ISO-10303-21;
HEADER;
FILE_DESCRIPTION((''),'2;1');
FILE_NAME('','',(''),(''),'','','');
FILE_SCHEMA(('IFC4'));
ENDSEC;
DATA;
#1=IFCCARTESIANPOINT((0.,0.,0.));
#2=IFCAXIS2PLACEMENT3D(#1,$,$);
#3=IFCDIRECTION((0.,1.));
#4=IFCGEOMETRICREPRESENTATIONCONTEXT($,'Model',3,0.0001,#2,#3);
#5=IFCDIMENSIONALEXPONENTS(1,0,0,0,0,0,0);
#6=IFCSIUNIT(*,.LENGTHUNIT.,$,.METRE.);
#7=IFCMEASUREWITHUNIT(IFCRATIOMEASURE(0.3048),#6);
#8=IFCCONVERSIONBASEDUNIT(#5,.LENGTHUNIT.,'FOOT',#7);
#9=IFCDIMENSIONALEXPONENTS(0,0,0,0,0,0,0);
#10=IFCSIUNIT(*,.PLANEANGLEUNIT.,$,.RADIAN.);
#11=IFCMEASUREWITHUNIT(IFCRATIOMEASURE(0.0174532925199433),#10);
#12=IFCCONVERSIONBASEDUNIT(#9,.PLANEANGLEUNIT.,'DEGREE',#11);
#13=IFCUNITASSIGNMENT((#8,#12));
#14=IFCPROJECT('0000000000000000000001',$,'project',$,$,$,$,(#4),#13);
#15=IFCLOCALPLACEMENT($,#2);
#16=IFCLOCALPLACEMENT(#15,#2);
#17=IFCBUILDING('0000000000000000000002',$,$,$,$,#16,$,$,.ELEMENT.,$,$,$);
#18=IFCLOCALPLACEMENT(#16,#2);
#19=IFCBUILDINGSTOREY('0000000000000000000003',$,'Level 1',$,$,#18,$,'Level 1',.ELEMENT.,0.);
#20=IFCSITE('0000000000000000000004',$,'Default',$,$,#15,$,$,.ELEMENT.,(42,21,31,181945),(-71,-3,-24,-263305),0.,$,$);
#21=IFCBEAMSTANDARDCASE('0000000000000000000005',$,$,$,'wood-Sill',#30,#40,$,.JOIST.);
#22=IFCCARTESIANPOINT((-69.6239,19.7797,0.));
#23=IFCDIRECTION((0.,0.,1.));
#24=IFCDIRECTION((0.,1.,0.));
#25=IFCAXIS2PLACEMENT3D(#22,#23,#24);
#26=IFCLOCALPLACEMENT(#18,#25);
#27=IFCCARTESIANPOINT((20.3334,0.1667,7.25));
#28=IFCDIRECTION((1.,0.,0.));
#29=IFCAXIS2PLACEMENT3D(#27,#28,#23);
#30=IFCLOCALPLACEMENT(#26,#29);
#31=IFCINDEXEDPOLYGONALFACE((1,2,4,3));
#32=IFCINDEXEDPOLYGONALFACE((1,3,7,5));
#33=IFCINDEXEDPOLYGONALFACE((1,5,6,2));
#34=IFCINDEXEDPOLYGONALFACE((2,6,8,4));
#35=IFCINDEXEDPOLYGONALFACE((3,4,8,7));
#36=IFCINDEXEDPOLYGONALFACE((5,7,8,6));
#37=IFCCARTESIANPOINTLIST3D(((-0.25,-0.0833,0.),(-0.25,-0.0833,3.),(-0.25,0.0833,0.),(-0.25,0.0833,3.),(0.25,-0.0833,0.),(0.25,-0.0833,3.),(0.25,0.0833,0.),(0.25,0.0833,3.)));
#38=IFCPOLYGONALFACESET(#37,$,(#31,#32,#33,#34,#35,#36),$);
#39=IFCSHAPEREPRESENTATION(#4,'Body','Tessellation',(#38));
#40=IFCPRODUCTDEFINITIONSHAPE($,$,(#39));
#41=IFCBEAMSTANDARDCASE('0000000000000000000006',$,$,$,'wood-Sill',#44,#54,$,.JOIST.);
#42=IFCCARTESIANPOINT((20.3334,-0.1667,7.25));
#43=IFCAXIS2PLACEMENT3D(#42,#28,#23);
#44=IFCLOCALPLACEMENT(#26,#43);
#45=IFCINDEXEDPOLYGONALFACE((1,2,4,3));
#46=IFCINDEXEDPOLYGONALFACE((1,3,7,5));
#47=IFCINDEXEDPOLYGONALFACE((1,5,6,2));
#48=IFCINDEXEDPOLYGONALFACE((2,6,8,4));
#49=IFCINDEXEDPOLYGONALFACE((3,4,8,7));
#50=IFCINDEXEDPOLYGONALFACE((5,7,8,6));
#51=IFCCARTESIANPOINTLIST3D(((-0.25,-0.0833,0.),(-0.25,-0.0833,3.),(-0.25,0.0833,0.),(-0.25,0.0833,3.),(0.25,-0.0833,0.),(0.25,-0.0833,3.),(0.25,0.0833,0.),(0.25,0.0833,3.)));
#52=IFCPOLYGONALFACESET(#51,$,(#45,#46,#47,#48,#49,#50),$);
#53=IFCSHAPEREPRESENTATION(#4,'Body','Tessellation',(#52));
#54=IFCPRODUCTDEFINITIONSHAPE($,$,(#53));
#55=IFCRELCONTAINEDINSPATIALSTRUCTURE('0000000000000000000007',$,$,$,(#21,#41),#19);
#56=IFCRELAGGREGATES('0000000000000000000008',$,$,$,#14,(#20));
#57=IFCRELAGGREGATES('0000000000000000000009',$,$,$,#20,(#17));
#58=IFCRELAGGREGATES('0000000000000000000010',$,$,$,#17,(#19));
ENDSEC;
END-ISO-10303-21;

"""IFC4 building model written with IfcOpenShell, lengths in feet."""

from ifc_helpers import new_model, entity, si_unit, converted_unit, direction, frame, origin, origin_with_axes, place, context, project, spatial, rectangle, extrude, element, save


model = new_model("IFC4")

# Units and contexts
model_context = context("Model", 3, precision=0.0001, world=origin(), true_north=direction((0.0, 1.0)))
ifc_project = project(units=[converted_unit("LENGTHUNIT", "FOOT", entity("IfcRatioMeasure", 0.3048), si_unit("LENGTHUNIT", "METRE"), dimensions=[1, 0, 0, 0, 0, 0, 0]), converted_unit("PLANEANGLEUNIT", "DEGREE", entity("IfcRatioMeasure", 0.0174532925199433), si_unit("PLANEANGLEUNIT", "RADIAN"), dimensions=[0, 0, 0, 0, 0, 0, 0])], contexts=[model_context])

# Site, building, storey
site_placement = place(None, origin())
site = spatial("IfcSite", under=ifc_project, at=site_placement, Name="Default", CompositionType="ELEMENT", RefLatitude=(42, 21, 31, 181945), RefLongitude=(-71, -3, -24, -263305), RefElevation=0.0)
building_placement = place(site_placement, origin())
building = spatial("IfcBuilding", under=site, at=building_placement, CompositionType="ELEMENT")
storey_placement = place(building_placement, origin())
storey = spatial("IfcBuildingStorey", under=building, at=storey_placement, Name="Level 1", LongName="Level 1", CompositionType="ELEMENT", Elevation=0.0)

# Shared definitions
placement_1 = place(storey_placement, frame((-69.6239, 19.7797, 0.0), z_axis=(0.0, 0.0, 1.0), x_axis=(0.0, 1.0, 0.0)))

# Beams
for number, where, z_axis, x_axis in (
    (1, (20.3334, 0.1667, 7.25), (1.0, 0.0, 0.0), (0.0, 0.0, 1.0)),
    (2, (20.3334, -0.1667, 7.25), (1.0, 0.0, 0.0), (0.0, 0.0, 1.0)),
):
    element("IfcBeamStandardCase", number, at=place(placement_1, frame(where, z_axis=z_axis, x_axis=x_axis)), inside=storey, ObjectType="wood-Sill", PredefinedType="JOIST", context=model_context, shape_type="SweptSolid", body=[
        extrude(rectangle(XDim=0.5, YDim=0.1667), origin_with_axes(), (0.0, 0.0, 1.0), 3.0),
    ])

save(model, "model.ifc")
